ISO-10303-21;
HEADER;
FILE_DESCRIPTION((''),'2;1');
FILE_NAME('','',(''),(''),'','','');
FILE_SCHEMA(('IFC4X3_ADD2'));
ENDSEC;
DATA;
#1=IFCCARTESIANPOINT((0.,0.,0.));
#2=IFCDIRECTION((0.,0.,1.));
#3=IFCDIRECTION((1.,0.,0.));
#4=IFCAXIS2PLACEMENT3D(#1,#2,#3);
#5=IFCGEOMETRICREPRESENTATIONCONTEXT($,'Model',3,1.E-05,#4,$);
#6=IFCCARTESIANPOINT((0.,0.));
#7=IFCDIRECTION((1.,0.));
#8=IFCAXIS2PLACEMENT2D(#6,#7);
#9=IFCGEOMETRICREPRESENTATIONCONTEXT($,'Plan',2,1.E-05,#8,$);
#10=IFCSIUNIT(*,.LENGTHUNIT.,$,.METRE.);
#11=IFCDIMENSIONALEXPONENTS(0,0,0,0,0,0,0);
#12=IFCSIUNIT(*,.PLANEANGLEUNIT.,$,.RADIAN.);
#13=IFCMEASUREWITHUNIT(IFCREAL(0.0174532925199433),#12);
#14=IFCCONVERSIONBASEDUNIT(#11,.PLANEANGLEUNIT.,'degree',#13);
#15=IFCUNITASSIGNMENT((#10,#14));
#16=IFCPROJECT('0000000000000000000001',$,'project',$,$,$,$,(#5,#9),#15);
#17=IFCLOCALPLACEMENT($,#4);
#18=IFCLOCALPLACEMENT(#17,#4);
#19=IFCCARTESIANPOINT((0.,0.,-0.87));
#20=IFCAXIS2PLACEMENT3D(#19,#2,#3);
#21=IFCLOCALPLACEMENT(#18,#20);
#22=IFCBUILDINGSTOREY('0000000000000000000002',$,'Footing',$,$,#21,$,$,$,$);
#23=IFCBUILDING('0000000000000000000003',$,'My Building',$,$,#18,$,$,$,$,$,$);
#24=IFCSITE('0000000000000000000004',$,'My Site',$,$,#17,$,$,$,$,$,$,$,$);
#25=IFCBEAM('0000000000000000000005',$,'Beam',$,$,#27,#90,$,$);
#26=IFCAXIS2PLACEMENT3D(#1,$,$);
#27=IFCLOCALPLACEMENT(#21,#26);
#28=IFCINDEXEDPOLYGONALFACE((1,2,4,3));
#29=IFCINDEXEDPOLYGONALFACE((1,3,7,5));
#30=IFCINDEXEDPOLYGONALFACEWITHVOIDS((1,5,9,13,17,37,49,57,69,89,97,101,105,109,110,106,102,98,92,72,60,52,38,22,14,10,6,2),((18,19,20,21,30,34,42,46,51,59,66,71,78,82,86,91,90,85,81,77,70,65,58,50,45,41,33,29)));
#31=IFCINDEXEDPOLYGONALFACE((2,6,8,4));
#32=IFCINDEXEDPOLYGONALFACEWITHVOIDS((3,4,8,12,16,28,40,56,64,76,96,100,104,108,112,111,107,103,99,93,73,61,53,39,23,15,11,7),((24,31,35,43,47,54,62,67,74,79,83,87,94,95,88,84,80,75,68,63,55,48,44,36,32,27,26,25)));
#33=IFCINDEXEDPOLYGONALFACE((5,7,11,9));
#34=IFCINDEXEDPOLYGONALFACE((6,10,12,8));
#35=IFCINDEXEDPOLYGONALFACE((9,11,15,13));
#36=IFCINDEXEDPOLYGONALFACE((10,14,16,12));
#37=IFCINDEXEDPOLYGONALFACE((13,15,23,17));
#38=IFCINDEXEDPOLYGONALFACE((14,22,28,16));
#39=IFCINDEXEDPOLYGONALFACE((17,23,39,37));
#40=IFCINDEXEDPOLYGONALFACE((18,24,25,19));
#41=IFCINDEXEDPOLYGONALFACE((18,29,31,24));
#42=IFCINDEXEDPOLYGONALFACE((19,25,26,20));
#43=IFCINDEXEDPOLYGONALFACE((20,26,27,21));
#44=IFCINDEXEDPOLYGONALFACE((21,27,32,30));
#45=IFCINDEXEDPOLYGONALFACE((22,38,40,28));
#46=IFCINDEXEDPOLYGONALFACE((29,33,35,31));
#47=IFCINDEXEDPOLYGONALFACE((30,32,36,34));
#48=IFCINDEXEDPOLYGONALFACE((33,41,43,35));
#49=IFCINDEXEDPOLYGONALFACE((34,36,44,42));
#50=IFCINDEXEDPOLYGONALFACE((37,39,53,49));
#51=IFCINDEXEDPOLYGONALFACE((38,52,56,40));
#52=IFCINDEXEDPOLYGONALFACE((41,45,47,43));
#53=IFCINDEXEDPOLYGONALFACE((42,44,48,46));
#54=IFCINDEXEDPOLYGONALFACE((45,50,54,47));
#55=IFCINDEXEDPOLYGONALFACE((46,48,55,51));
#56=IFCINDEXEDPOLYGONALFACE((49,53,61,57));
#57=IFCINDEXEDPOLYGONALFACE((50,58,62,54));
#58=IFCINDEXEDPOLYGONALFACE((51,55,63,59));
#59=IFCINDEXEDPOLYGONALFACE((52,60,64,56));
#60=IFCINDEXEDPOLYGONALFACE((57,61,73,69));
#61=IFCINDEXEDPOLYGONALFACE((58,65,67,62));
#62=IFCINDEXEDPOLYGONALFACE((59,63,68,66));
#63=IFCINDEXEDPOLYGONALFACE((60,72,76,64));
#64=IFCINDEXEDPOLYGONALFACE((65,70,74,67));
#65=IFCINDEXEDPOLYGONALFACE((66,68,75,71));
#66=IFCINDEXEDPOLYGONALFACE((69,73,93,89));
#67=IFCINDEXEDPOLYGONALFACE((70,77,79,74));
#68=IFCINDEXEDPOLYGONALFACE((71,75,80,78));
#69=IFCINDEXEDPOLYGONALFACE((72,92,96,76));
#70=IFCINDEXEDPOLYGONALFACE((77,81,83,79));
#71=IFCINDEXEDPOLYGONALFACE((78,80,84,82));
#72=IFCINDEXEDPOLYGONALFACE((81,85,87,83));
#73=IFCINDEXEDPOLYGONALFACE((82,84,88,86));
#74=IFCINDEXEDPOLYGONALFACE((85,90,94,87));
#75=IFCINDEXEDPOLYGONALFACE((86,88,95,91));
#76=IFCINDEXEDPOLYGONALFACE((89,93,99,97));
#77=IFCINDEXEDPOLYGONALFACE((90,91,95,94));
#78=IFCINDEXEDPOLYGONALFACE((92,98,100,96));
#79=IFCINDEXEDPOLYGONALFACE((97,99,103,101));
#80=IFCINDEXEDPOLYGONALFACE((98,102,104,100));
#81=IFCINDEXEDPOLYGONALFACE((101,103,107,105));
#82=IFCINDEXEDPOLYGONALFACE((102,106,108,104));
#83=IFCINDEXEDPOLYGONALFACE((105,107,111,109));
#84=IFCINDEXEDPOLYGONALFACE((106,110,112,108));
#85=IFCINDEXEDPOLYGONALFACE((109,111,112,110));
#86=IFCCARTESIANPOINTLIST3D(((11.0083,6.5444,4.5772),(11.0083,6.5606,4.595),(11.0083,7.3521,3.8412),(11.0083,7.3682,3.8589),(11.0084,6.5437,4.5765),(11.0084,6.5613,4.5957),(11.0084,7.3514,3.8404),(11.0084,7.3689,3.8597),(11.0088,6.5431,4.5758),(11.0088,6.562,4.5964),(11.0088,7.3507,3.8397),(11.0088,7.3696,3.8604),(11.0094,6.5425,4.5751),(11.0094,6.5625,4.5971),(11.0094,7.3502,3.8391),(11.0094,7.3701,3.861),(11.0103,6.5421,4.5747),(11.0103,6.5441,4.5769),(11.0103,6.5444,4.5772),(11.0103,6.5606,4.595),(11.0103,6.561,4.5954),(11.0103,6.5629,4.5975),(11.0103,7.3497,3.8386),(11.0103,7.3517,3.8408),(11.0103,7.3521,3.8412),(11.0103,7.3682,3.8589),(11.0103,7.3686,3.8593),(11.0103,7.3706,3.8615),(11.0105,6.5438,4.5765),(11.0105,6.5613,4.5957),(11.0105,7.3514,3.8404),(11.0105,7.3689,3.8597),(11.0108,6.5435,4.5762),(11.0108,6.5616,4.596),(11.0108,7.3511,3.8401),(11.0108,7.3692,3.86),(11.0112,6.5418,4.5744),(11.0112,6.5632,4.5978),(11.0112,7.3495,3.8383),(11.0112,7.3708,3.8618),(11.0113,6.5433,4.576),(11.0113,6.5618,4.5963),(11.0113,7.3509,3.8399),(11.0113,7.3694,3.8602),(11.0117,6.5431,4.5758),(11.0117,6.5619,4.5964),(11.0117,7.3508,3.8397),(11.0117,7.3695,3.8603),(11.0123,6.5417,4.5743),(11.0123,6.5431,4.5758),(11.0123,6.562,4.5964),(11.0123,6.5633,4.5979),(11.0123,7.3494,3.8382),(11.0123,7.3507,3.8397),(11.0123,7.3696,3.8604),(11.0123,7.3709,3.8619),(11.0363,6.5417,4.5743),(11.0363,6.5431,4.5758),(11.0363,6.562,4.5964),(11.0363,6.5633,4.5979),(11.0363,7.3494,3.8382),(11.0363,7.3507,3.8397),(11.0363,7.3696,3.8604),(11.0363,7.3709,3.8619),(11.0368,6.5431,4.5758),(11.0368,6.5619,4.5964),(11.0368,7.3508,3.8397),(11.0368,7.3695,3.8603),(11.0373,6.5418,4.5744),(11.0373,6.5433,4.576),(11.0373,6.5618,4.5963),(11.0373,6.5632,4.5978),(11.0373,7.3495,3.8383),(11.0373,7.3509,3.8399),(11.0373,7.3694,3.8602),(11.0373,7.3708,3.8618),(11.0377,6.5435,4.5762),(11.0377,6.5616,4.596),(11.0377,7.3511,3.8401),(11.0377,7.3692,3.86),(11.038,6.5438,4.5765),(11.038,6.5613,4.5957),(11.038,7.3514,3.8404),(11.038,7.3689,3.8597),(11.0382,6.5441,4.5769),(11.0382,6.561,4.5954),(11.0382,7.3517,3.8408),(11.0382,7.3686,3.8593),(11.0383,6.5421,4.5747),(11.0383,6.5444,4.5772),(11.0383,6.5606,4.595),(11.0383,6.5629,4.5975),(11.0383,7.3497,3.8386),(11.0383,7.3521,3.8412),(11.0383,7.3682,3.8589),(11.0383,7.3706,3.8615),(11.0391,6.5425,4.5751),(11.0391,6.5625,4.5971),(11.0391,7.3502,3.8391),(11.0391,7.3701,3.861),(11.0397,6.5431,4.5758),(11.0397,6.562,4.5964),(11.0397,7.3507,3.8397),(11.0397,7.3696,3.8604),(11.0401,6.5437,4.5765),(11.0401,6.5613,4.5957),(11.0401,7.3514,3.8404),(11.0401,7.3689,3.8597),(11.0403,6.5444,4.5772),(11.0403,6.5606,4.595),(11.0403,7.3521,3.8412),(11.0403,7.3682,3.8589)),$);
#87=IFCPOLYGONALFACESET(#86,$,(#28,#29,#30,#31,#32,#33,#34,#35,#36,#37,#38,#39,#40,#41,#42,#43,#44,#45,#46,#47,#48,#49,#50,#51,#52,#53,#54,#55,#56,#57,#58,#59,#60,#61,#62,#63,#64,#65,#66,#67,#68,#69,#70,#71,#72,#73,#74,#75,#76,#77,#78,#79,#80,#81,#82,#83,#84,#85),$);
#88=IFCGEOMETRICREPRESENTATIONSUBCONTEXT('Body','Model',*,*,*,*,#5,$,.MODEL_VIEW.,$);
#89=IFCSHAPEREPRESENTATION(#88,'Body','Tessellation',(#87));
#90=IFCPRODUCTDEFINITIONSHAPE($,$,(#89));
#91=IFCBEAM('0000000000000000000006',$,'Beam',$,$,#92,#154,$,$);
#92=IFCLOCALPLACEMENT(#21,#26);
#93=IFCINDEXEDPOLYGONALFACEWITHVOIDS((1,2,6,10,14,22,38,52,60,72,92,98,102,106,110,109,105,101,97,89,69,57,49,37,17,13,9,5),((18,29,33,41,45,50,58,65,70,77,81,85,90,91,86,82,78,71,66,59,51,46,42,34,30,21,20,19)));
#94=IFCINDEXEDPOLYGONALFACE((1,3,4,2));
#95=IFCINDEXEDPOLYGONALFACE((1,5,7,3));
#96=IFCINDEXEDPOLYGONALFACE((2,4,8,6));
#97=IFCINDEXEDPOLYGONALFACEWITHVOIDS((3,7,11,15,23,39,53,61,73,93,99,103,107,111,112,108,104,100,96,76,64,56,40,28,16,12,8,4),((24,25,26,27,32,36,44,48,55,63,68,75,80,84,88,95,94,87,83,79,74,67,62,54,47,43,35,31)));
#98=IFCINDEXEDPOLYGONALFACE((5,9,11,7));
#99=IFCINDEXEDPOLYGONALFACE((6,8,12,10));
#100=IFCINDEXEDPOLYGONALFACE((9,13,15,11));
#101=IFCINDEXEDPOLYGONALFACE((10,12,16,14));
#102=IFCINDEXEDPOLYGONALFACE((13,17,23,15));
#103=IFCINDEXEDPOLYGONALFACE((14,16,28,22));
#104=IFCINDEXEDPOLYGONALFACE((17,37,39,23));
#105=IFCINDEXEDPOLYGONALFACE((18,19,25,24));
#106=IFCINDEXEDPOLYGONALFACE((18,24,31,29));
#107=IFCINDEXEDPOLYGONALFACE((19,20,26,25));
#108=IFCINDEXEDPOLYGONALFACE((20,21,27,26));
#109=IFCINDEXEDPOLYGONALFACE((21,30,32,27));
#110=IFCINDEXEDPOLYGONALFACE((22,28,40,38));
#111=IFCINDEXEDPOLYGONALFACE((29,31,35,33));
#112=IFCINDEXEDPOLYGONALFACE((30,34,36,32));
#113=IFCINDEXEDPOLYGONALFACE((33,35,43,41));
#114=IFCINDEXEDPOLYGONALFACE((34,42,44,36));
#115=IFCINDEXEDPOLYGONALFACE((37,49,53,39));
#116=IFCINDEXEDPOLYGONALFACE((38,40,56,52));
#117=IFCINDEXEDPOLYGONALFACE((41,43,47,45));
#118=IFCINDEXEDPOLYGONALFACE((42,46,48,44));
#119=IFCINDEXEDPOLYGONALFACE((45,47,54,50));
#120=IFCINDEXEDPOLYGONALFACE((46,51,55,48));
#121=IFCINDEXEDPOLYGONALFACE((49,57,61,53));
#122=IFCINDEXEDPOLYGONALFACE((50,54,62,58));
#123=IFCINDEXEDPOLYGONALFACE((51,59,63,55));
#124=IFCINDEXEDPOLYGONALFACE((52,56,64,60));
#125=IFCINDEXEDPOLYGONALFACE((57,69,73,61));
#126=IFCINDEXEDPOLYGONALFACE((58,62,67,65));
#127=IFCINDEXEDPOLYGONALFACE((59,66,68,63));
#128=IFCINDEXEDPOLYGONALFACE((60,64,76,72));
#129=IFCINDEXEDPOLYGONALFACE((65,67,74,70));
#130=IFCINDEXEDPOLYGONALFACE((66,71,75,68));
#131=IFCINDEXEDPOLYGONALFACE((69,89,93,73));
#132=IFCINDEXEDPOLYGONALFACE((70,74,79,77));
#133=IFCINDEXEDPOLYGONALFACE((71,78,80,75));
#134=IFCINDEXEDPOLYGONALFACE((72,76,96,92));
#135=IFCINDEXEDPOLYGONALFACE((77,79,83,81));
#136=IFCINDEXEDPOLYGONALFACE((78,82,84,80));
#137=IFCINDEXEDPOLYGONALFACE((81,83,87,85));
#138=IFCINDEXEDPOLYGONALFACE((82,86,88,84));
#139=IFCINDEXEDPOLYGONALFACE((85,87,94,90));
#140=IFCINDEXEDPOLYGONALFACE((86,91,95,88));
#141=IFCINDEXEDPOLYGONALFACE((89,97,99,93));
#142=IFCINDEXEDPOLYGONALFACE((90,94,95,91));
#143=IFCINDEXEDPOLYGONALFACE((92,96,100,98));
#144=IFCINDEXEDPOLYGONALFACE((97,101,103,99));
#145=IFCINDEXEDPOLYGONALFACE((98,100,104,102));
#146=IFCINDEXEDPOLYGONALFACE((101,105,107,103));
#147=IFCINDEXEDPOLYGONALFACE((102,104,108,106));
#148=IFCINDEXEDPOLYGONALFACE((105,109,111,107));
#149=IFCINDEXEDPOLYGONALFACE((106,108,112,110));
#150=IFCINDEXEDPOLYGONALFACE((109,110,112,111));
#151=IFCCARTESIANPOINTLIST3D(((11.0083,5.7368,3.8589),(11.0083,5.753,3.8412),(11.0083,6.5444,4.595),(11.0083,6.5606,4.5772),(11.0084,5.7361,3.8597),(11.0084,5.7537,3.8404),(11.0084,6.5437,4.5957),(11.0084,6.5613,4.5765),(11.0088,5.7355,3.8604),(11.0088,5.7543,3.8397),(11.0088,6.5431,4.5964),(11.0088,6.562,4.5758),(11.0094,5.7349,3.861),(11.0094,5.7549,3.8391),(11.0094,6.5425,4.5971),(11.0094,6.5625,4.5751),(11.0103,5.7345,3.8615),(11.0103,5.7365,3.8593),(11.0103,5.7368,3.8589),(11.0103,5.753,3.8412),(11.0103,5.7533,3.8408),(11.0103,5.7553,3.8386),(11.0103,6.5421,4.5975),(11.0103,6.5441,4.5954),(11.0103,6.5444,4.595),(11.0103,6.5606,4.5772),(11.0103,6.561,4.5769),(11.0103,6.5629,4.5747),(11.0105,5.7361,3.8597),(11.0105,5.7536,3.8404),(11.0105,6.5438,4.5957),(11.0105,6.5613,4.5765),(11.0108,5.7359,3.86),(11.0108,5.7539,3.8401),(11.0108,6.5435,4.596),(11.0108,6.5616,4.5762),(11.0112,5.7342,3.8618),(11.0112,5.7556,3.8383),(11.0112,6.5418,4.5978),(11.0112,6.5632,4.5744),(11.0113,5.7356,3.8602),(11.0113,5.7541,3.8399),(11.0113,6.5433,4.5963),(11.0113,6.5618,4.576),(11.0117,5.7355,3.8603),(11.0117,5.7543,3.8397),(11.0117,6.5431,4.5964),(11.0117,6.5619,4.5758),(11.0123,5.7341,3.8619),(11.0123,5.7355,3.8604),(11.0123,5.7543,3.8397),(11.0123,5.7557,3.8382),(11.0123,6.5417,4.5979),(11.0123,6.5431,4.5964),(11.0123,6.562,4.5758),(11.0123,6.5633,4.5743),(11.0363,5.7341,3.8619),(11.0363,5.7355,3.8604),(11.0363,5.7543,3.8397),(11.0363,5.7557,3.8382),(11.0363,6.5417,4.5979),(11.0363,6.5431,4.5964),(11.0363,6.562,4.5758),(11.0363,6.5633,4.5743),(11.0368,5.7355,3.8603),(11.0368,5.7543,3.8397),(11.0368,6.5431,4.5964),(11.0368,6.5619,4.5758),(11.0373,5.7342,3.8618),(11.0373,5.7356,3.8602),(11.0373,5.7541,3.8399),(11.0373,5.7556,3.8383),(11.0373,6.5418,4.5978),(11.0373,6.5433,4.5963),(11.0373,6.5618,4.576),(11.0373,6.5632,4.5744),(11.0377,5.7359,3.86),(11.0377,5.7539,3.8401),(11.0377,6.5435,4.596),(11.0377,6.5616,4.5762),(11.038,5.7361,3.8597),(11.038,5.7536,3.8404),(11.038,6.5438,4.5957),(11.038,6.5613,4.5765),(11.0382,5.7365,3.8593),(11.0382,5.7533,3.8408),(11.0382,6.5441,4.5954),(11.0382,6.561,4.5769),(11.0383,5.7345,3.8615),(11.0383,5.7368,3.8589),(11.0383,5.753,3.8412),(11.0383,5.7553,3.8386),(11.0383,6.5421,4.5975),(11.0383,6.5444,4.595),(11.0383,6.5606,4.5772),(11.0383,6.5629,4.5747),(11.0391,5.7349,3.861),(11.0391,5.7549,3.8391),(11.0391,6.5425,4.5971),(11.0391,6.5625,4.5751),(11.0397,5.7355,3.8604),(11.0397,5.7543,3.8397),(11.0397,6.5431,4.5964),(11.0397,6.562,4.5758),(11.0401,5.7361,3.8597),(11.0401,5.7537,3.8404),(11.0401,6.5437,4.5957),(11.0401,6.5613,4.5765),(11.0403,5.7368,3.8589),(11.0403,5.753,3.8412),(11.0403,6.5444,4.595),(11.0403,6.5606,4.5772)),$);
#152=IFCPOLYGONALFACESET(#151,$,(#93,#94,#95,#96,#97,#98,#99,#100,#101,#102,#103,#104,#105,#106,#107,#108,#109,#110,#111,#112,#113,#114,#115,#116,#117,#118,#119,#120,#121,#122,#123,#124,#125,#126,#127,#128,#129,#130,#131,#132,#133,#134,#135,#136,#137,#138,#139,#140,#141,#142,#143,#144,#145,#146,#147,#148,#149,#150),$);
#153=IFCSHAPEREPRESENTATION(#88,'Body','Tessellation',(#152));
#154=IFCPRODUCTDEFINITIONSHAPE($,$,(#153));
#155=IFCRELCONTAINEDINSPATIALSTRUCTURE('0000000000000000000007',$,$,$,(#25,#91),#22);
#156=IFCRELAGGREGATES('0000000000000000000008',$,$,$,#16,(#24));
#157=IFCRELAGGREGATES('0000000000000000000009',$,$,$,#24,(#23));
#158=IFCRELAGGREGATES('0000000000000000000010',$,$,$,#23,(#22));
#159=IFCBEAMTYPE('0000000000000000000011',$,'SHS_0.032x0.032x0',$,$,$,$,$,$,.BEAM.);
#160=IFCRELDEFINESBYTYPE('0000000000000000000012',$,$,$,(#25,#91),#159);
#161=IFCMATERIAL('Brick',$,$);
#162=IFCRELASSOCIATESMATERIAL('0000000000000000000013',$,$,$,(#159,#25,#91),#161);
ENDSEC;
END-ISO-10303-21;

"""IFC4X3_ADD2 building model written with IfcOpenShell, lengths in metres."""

from ifc_helpers import new_model, entity, si_unit, converted_unit, frame, origin_with_axes, origin_2d_with_axis, place, context, subcontext, project, spatial, hollow_rectangle, extrude, material, material_profile, profile_set, profile_usage, type_object, element, save


model = new_model("IFC4X3_ADD2")

# Units and contexts
model_context = context("Model", 3, precision=1e-05, world=origin_with_axes())
plan_context = context("Plan", 2, precision=1e-05, world=origin_2d_with_axis())
body_context = subcontext(model_context, "Body", "Model", "MODEL_VIEW")
ifc_project = project(units=[si_unit("LENGTHUNIT", "METRE"), converted_unit("PLANEANGLEUNIT", "degree", entity("IfcReal", 0.0174532925199433), si_unit("PLANEANGLEUNIT", "RADIAN"), dimensions=[0, 0, 0, 0, 0, 0, 0])], contexts=[model_context, plan_context])

# Site, building, storey
site_placement = place(None, origin_with_axes())
site = spatial("IfcSite", under=ifc_project, at=site_placement, Name="My Site")
building_placement = place(site_placement, origin_with_axes())
building = spatial("IfcBuilding", under=site, at=building_placement, Name="My Building")
storey_placement = place(building_placement, frame((0.0, 0.0, -0.87), z_axis=(0.0, 0.0, 1.0), x_axis=(1.0, 0.0, 0.0)))
storey = spatial("IfcBuildingStorey", under=building, at=storey_placement, Name="Footing")

# Beams
ifc_material_1 = material(Name="Brick")
ifc_material_profile = material_profile(ifc_material_1, hollow_rectangle(XDim=0.032, YDim=0.032, WallThickness=0.002, InnerFilletRadius=0.002, OuterFilletRadius=0.004))
ifc_profile_set = profile_set([ifc_material_profile])
beam_type_1 = type_object("IfcBeamType", Name="SHS_0.032x0.032x0", PredefinedType="BEAM", material=ifc_profile_set)
ifc_profile_usage_1 = profile_usage(ifc_profile_set, cardinal=5)
beam_1_placement = place(storey_placement, frame((11.0243, 6.5525, 4.5861), z_axis=(0.0, 0.739099, -0.673597), x_axis=(-1.0, 0.0, 0.0)))
element("IfcBeam", 1, at=beam_1_placement, inside=storey, type_object=beam_type_1, material=ifc_profile_usage_1, Name="Beam", context=body_context, shape_type="SweptSolid", body=[
    extrude(hollow_rectangle(XDim=0.032, YDim=0.032, WallThickness=0.002, InnerFilletRadius=0.002, OuterFilletRadius=0.004), origin_with_axes(), (0.0, 0.0, 1.0), 1.0927),
])
ifc_profile_usage_2 = profile_usage(ifc_profile_set, cardinal=5)
beam_2_placement = place(storey_placement, frame((11.0243, 6.5525, 4.5861), z_axis=(0.0, -0.739099, -0.673597), x_axis=(1.0, 0.0, 0.0)))
element("IfcBeam", 2, at=beam_2_placement, inside=storey, type_object=beam_type_1, material=ifc_profile_usage_2, Name="Beam", context=body_context, shape_type="SweptSolid", body=[
    extrude(hollow_rectangle(XDim=0.032, YDim=0.032, WallThickness=0.002, InnerFilletRadius=0.002, OuterFilletRadius=0.004), origin_with_axes(), (0.0, 0.0, 1.0), 1.0927),
])

save(model, "model.ifc")
